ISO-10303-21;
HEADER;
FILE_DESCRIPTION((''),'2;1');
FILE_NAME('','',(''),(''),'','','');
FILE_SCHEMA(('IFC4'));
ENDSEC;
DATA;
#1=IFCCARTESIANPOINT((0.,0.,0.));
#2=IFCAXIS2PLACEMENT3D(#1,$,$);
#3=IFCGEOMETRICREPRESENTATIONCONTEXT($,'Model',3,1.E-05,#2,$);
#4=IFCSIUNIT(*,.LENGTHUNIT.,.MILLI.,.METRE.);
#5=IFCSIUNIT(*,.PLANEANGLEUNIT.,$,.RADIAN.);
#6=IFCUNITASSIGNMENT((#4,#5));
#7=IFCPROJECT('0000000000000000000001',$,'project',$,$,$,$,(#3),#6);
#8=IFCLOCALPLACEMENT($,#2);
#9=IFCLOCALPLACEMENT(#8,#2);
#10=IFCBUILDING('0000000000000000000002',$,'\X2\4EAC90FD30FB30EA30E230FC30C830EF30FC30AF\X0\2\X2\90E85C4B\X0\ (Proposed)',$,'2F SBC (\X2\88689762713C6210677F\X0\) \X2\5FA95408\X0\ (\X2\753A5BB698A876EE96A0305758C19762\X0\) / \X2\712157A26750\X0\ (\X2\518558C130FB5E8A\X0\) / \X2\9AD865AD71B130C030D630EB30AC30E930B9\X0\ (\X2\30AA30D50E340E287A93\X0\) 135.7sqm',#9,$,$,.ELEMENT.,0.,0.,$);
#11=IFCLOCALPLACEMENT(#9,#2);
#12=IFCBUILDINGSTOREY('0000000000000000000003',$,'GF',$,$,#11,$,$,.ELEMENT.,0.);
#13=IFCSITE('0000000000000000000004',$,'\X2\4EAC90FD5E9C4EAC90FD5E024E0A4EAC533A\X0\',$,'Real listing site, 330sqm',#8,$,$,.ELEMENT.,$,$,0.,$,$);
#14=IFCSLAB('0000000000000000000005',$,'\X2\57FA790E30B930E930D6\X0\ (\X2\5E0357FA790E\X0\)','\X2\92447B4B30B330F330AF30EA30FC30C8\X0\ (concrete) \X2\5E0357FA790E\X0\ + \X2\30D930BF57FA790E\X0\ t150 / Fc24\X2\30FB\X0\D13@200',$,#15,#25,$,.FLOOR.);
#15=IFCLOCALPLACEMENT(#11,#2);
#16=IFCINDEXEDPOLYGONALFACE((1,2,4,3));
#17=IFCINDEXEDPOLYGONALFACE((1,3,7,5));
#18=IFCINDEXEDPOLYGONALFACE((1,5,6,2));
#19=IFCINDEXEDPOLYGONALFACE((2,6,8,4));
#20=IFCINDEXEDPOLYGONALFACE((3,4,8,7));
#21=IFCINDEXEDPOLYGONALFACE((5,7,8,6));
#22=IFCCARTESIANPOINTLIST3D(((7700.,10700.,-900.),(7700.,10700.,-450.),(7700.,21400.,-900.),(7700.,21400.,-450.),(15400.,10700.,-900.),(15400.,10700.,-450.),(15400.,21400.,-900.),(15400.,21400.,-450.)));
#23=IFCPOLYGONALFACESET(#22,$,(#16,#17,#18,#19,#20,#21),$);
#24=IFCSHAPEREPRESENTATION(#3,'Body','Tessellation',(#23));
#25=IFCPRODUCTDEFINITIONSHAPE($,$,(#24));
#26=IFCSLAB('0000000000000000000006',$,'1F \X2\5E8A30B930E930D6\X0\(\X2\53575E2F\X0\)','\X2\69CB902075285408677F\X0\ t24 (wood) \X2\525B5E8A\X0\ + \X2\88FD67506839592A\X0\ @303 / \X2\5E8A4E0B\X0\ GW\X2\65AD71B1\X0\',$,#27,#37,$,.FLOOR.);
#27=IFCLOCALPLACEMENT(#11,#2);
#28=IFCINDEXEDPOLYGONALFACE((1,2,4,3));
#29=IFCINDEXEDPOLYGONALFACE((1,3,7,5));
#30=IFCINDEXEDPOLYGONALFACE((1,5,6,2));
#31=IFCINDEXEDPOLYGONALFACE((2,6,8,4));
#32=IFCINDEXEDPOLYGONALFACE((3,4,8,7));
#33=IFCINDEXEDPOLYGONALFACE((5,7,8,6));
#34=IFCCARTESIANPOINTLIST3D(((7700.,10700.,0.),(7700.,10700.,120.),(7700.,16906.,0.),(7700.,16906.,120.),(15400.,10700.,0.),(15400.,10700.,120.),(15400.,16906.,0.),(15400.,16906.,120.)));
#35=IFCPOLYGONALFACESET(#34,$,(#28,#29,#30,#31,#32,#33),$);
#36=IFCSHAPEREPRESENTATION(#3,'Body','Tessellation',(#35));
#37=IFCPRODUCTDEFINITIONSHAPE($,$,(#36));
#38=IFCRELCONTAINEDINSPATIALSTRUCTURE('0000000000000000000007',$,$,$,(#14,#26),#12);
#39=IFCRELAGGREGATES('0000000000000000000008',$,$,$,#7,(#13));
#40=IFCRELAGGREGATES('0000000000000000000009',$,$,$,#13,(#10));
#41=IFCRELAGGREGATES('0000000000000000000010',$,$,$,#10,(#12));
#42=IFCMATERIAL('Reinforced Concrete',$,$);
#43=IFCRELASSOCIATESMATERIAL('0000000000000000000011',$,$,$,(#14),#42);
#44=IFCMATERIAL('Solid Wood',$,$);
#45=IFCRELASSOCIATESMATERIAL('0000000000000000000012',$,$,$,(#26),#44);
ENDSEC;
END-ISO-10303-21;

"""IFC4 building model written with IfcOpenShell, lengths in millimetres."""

from ifc_helpers import new_model, si_unit, frame, frame_2d, origin, place, context, project, spatial, rectangle, extrude, material, element, save


model = new_model("IFC4")

# Units and contexts
model_context = context("Model", 3, precision=1e-05, world=origin())
ifc_project = project(units=[si_unit("LENGTHUNIT", "METRE", prefix="MILLI"), si_unit("PLANEANGLEUNIT", "RADIAN")], contexts=[model_context])

# Site, building, storey
site_placement = place(None, origin())
site = spatial("IfcSite", under=ifc_project, at=site_placement, Name="京都府京都市上京区", ObjectType="Real listing site, 330sqm", CompositionType="ELEMENT", RefElevation=0.0)
building_placement = place(site_placement, origin())
building = spatial("IfcBuilding", under=site, at=building_placement, Name="京都・リモートワーク2部屋 (Proposed)", ObjectType="2F SBC (表面焼成板) 復合 (町家風目隠し壁面) / 無垢材 (内壁・床) / 高断熱ダブルガラス (オフิศ窓) 135.7sqm", CompositionType="ELEMENT", ElevationOfRefHeight=0.0, ElevationOfTerrain=0.0)
storey_placement = place(building_placement, origin())
storey = spatial("IfcBuildingStorey", under=building, at=storey_placement, Name="GF", CompositionType="ELEMENT", Elevation=0.0)

# Shared definitions
ifc_material_1 = material(Name="Solid Wood")

# Slabs
ifc_material_2 = material(Name="Reinforced Concrete")
slab_1_placement = place(storey_placement, frame((3850.0, 5350.0, -450.0)))
element("IfcSlab", 1, at=slab_1_placement, inside=storey, material=ifc_material_2, Name="基礎スラブ (布基礎)", Description="鉄筋コンクリート (concrete) 布基礎 + ベタ基礎 t150 / Fc24・D13@200", PredefinedType="FLOOR", context=model_context, shape_type="SweptSolid", body=[
    extrude(rectangle(XDim=7700.0, YDim=10700.0, at=frame_2d((3850.0, 5350.0))), frame((3850.0, 5350.0, -450.0)), (0.0, 0.0, 1.0), 450.0),
])
slab_2_placement = place(storey_placement, frame((3850.0, 5350.0, 0.0)))
element("IfcSlab", 2, at=slab_2_placement, inside=storey, material=ifc_material_1, Name="1F 床スラブ(南帯)", Description="構造用合板 t24 (wood) 剛床 + 製材根太 @303 / 床下 GW断熱", PredefinedType="FLOOR", context=model_context, shape_type="SweptSolid", body=[
    extrude(rectangle(XDim=7700.0, YDim=6206.0, at=frame_2d((3850.0, 3103.0))), frame((3850.0, 5350.0, 0.0)), (0.0, 0.0, 1.0), 120.0),
])

save(model, "model.ifc")
